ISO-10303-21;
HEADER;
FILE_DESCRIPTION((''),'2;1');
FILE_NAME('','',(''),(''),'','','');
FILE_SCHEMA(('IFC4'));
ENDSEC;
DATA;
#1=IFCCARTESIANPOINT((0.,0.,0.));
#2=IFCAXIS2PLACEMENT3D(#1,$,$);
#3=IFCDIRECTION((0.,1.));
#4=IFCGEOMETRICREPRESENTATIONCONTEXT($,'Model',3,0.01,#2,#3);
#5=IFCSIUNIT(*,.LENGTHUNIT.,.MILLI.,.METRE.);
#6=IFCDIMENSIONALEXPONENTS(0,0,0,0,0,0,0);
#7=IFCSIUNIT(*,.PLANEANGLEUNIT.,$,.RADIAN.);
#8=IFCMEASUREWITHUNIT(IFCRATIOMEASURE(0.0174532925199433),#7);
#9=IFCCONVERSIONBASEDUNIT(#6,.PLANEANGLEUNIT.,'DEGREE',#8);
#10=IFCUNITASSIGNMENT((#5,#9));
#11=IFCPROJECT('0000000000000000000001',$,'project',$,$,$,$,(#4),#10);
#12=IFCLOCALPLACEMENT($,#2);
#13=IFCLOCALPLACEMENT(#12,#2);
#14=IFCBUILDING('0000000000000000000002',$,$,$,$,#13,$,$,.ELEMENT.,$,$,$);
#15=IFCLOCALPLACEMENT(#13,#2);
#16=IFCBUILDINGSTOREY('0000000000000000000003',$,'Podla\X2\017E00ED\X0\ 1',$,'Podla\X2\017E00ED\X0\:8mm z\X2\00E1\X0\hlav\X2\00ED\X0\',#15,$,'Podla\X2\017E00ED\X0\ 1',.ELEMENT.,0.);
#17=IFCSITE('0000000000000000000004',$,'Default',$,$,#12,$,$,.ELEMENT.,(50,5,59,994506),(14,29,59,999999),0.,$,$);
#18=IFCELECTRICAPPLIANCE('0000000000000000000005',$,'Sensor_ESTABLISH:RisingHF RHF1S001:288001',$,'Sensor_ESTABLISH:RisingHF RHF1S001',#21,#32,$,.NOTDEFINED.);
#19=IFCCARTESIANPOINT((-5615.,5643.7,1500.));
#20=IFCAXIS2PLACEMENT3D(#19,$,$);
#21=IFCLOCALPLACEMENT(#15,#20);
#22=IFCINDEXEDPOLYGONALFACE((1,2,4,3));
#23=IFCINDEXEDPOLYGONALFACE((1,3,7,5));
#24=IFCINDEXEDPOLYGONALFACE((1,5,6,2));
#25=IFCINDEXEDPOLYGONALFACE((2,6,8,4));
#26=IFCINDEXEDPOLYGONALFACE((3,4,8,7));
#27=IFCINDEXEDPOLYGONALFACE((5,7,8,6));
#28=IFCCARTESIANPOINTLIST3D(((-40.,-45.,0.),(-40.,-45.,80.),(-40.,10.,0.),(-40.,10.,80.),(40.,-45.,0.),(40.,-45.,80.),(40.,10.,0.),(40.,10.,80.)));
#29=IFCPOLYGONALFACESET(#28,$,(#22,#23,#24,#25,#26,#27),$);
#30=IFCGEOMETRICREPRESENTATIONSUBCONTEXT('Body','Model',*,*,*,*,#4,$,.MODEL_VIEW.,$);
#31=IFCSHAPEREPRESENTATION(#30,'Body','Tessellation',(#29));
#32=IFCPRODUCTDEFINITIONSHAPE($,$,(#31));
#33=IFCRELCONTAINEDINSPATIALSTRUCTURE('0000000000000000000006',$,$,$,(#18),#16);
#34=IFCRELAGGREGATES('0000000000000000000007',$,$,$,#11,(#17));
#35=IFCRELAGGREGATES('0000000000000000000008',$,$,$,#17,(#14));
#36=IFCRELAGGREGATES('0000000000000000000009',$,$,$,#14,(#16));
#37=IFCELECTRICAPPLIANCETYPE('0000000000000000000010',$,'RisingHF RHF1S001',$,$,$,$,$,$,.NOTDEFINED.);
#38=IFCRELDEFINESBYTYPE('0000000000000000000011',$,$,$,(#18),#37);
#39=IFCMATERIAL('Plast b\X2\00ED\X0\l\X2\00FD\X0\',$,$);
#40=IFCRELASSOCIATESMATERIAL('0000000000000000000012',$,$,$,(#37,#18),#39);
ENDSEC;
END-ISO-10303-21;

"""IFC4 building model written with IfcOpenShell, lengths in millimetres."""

from ifc_helpers import new_model, entity, si_unit, converted_unit, direction, frame, frame_2d, origin, place, context, subcontext, project, spatial, rectangle, extrude, source, transform, mapped, material, type_object, type_shapes, element, save


model = new_model("IFC4")

# Units and contexts
model_context = context("Model", 3, precision=0.01, world=origin(), true_north=direction((0.0, 1.0)))
body_context = subcontext(model_context, "Body", "Model", "MODEL_VIEW")
ifc_project = project(units=[si_unit("LENGTHUNIT", "METRE", prefix="MILLI"), converted_unit("PLANEANGLEUNIT", "DEGREE", entity("IfcRatioMeasure", 0.0174532925199433), si_unit("PLANEANGLEUNIT", "RADIAN"), dimensions=[0, 0, 0, 0, 0, 0, 0])], contexts=[model_context])

# Site, building, storey
site_placement = place(None, origin())
site = spatial("IfcSite", under=ifc_project, at=site_placement, Name="Default", CompositionType="ELEMENT", RefLatitude=(50, 5, 59, 994506), RefLongitude=(14, 29, 59, 999999), RefElevation=0.0)
building_placement = place(site_placement, origin())
building = spatial("IfcBuilding", under=site, at=building_placement, CompositionType="ELEMENT")
storey_placement = place(building_placement, origin())
storey = spatial("IfcBuildingStorey", under=building, at=storey_placement, Name="Podlaží 1", ObjectType="Podlaží:8mm záhlaví", LongName="Podlaží 1", CompositionType="ELEMENT", Elevation=0.0)

# Electric appliance
ifc_material_1 = material(Name="Plast bílý")
electric_appliance_type = type_object("IfcElectricApplianceType", Name="RisingHF RHF1S001", PredefinedType="NOTDEFINED", material=ifc_material_1)
shared_shape_1 = source(origin(), body_context, "Body", "SweptSolid", [
    extrude(rectangle(XDim=80.0, YDim=55.0, at=frame_2d((0.0, 0.0), x_axis=(1.0, 0.0))), frame((0.0, -17.5, 0.0), z_axis=(0.0, 0.0, 1.0), x_axis=(-1.0, 0.0, 0.0)), (0.0, 0.0, 1.0), 80.0),
])
type_shapes(electric_appliance_type, [shared_shape_1])
electric_appliance_placement = place(storey_placement, frame((-5615.0, 5643.7, 1500.0)))
element("IfcElectricAppliance", 1, at=electric_appliance_placement, inside=storey, type_object=electric_appliance_type, material=ifc_material_1, Name="Sensor_ESTABLISH:RisingHF RHF1S001:288001", ObjectType="Sensor_ESTABLISH:RisingHF RHF1S001", PredefinedType="NOTDEFINED", context=body_context, shape_type="MappedRepresentation", body=[
    mapped(shared_shape_1, transform((0.0, 0.0, 0.0), scale=1.0)),
])

save(model, "model.ifc")
